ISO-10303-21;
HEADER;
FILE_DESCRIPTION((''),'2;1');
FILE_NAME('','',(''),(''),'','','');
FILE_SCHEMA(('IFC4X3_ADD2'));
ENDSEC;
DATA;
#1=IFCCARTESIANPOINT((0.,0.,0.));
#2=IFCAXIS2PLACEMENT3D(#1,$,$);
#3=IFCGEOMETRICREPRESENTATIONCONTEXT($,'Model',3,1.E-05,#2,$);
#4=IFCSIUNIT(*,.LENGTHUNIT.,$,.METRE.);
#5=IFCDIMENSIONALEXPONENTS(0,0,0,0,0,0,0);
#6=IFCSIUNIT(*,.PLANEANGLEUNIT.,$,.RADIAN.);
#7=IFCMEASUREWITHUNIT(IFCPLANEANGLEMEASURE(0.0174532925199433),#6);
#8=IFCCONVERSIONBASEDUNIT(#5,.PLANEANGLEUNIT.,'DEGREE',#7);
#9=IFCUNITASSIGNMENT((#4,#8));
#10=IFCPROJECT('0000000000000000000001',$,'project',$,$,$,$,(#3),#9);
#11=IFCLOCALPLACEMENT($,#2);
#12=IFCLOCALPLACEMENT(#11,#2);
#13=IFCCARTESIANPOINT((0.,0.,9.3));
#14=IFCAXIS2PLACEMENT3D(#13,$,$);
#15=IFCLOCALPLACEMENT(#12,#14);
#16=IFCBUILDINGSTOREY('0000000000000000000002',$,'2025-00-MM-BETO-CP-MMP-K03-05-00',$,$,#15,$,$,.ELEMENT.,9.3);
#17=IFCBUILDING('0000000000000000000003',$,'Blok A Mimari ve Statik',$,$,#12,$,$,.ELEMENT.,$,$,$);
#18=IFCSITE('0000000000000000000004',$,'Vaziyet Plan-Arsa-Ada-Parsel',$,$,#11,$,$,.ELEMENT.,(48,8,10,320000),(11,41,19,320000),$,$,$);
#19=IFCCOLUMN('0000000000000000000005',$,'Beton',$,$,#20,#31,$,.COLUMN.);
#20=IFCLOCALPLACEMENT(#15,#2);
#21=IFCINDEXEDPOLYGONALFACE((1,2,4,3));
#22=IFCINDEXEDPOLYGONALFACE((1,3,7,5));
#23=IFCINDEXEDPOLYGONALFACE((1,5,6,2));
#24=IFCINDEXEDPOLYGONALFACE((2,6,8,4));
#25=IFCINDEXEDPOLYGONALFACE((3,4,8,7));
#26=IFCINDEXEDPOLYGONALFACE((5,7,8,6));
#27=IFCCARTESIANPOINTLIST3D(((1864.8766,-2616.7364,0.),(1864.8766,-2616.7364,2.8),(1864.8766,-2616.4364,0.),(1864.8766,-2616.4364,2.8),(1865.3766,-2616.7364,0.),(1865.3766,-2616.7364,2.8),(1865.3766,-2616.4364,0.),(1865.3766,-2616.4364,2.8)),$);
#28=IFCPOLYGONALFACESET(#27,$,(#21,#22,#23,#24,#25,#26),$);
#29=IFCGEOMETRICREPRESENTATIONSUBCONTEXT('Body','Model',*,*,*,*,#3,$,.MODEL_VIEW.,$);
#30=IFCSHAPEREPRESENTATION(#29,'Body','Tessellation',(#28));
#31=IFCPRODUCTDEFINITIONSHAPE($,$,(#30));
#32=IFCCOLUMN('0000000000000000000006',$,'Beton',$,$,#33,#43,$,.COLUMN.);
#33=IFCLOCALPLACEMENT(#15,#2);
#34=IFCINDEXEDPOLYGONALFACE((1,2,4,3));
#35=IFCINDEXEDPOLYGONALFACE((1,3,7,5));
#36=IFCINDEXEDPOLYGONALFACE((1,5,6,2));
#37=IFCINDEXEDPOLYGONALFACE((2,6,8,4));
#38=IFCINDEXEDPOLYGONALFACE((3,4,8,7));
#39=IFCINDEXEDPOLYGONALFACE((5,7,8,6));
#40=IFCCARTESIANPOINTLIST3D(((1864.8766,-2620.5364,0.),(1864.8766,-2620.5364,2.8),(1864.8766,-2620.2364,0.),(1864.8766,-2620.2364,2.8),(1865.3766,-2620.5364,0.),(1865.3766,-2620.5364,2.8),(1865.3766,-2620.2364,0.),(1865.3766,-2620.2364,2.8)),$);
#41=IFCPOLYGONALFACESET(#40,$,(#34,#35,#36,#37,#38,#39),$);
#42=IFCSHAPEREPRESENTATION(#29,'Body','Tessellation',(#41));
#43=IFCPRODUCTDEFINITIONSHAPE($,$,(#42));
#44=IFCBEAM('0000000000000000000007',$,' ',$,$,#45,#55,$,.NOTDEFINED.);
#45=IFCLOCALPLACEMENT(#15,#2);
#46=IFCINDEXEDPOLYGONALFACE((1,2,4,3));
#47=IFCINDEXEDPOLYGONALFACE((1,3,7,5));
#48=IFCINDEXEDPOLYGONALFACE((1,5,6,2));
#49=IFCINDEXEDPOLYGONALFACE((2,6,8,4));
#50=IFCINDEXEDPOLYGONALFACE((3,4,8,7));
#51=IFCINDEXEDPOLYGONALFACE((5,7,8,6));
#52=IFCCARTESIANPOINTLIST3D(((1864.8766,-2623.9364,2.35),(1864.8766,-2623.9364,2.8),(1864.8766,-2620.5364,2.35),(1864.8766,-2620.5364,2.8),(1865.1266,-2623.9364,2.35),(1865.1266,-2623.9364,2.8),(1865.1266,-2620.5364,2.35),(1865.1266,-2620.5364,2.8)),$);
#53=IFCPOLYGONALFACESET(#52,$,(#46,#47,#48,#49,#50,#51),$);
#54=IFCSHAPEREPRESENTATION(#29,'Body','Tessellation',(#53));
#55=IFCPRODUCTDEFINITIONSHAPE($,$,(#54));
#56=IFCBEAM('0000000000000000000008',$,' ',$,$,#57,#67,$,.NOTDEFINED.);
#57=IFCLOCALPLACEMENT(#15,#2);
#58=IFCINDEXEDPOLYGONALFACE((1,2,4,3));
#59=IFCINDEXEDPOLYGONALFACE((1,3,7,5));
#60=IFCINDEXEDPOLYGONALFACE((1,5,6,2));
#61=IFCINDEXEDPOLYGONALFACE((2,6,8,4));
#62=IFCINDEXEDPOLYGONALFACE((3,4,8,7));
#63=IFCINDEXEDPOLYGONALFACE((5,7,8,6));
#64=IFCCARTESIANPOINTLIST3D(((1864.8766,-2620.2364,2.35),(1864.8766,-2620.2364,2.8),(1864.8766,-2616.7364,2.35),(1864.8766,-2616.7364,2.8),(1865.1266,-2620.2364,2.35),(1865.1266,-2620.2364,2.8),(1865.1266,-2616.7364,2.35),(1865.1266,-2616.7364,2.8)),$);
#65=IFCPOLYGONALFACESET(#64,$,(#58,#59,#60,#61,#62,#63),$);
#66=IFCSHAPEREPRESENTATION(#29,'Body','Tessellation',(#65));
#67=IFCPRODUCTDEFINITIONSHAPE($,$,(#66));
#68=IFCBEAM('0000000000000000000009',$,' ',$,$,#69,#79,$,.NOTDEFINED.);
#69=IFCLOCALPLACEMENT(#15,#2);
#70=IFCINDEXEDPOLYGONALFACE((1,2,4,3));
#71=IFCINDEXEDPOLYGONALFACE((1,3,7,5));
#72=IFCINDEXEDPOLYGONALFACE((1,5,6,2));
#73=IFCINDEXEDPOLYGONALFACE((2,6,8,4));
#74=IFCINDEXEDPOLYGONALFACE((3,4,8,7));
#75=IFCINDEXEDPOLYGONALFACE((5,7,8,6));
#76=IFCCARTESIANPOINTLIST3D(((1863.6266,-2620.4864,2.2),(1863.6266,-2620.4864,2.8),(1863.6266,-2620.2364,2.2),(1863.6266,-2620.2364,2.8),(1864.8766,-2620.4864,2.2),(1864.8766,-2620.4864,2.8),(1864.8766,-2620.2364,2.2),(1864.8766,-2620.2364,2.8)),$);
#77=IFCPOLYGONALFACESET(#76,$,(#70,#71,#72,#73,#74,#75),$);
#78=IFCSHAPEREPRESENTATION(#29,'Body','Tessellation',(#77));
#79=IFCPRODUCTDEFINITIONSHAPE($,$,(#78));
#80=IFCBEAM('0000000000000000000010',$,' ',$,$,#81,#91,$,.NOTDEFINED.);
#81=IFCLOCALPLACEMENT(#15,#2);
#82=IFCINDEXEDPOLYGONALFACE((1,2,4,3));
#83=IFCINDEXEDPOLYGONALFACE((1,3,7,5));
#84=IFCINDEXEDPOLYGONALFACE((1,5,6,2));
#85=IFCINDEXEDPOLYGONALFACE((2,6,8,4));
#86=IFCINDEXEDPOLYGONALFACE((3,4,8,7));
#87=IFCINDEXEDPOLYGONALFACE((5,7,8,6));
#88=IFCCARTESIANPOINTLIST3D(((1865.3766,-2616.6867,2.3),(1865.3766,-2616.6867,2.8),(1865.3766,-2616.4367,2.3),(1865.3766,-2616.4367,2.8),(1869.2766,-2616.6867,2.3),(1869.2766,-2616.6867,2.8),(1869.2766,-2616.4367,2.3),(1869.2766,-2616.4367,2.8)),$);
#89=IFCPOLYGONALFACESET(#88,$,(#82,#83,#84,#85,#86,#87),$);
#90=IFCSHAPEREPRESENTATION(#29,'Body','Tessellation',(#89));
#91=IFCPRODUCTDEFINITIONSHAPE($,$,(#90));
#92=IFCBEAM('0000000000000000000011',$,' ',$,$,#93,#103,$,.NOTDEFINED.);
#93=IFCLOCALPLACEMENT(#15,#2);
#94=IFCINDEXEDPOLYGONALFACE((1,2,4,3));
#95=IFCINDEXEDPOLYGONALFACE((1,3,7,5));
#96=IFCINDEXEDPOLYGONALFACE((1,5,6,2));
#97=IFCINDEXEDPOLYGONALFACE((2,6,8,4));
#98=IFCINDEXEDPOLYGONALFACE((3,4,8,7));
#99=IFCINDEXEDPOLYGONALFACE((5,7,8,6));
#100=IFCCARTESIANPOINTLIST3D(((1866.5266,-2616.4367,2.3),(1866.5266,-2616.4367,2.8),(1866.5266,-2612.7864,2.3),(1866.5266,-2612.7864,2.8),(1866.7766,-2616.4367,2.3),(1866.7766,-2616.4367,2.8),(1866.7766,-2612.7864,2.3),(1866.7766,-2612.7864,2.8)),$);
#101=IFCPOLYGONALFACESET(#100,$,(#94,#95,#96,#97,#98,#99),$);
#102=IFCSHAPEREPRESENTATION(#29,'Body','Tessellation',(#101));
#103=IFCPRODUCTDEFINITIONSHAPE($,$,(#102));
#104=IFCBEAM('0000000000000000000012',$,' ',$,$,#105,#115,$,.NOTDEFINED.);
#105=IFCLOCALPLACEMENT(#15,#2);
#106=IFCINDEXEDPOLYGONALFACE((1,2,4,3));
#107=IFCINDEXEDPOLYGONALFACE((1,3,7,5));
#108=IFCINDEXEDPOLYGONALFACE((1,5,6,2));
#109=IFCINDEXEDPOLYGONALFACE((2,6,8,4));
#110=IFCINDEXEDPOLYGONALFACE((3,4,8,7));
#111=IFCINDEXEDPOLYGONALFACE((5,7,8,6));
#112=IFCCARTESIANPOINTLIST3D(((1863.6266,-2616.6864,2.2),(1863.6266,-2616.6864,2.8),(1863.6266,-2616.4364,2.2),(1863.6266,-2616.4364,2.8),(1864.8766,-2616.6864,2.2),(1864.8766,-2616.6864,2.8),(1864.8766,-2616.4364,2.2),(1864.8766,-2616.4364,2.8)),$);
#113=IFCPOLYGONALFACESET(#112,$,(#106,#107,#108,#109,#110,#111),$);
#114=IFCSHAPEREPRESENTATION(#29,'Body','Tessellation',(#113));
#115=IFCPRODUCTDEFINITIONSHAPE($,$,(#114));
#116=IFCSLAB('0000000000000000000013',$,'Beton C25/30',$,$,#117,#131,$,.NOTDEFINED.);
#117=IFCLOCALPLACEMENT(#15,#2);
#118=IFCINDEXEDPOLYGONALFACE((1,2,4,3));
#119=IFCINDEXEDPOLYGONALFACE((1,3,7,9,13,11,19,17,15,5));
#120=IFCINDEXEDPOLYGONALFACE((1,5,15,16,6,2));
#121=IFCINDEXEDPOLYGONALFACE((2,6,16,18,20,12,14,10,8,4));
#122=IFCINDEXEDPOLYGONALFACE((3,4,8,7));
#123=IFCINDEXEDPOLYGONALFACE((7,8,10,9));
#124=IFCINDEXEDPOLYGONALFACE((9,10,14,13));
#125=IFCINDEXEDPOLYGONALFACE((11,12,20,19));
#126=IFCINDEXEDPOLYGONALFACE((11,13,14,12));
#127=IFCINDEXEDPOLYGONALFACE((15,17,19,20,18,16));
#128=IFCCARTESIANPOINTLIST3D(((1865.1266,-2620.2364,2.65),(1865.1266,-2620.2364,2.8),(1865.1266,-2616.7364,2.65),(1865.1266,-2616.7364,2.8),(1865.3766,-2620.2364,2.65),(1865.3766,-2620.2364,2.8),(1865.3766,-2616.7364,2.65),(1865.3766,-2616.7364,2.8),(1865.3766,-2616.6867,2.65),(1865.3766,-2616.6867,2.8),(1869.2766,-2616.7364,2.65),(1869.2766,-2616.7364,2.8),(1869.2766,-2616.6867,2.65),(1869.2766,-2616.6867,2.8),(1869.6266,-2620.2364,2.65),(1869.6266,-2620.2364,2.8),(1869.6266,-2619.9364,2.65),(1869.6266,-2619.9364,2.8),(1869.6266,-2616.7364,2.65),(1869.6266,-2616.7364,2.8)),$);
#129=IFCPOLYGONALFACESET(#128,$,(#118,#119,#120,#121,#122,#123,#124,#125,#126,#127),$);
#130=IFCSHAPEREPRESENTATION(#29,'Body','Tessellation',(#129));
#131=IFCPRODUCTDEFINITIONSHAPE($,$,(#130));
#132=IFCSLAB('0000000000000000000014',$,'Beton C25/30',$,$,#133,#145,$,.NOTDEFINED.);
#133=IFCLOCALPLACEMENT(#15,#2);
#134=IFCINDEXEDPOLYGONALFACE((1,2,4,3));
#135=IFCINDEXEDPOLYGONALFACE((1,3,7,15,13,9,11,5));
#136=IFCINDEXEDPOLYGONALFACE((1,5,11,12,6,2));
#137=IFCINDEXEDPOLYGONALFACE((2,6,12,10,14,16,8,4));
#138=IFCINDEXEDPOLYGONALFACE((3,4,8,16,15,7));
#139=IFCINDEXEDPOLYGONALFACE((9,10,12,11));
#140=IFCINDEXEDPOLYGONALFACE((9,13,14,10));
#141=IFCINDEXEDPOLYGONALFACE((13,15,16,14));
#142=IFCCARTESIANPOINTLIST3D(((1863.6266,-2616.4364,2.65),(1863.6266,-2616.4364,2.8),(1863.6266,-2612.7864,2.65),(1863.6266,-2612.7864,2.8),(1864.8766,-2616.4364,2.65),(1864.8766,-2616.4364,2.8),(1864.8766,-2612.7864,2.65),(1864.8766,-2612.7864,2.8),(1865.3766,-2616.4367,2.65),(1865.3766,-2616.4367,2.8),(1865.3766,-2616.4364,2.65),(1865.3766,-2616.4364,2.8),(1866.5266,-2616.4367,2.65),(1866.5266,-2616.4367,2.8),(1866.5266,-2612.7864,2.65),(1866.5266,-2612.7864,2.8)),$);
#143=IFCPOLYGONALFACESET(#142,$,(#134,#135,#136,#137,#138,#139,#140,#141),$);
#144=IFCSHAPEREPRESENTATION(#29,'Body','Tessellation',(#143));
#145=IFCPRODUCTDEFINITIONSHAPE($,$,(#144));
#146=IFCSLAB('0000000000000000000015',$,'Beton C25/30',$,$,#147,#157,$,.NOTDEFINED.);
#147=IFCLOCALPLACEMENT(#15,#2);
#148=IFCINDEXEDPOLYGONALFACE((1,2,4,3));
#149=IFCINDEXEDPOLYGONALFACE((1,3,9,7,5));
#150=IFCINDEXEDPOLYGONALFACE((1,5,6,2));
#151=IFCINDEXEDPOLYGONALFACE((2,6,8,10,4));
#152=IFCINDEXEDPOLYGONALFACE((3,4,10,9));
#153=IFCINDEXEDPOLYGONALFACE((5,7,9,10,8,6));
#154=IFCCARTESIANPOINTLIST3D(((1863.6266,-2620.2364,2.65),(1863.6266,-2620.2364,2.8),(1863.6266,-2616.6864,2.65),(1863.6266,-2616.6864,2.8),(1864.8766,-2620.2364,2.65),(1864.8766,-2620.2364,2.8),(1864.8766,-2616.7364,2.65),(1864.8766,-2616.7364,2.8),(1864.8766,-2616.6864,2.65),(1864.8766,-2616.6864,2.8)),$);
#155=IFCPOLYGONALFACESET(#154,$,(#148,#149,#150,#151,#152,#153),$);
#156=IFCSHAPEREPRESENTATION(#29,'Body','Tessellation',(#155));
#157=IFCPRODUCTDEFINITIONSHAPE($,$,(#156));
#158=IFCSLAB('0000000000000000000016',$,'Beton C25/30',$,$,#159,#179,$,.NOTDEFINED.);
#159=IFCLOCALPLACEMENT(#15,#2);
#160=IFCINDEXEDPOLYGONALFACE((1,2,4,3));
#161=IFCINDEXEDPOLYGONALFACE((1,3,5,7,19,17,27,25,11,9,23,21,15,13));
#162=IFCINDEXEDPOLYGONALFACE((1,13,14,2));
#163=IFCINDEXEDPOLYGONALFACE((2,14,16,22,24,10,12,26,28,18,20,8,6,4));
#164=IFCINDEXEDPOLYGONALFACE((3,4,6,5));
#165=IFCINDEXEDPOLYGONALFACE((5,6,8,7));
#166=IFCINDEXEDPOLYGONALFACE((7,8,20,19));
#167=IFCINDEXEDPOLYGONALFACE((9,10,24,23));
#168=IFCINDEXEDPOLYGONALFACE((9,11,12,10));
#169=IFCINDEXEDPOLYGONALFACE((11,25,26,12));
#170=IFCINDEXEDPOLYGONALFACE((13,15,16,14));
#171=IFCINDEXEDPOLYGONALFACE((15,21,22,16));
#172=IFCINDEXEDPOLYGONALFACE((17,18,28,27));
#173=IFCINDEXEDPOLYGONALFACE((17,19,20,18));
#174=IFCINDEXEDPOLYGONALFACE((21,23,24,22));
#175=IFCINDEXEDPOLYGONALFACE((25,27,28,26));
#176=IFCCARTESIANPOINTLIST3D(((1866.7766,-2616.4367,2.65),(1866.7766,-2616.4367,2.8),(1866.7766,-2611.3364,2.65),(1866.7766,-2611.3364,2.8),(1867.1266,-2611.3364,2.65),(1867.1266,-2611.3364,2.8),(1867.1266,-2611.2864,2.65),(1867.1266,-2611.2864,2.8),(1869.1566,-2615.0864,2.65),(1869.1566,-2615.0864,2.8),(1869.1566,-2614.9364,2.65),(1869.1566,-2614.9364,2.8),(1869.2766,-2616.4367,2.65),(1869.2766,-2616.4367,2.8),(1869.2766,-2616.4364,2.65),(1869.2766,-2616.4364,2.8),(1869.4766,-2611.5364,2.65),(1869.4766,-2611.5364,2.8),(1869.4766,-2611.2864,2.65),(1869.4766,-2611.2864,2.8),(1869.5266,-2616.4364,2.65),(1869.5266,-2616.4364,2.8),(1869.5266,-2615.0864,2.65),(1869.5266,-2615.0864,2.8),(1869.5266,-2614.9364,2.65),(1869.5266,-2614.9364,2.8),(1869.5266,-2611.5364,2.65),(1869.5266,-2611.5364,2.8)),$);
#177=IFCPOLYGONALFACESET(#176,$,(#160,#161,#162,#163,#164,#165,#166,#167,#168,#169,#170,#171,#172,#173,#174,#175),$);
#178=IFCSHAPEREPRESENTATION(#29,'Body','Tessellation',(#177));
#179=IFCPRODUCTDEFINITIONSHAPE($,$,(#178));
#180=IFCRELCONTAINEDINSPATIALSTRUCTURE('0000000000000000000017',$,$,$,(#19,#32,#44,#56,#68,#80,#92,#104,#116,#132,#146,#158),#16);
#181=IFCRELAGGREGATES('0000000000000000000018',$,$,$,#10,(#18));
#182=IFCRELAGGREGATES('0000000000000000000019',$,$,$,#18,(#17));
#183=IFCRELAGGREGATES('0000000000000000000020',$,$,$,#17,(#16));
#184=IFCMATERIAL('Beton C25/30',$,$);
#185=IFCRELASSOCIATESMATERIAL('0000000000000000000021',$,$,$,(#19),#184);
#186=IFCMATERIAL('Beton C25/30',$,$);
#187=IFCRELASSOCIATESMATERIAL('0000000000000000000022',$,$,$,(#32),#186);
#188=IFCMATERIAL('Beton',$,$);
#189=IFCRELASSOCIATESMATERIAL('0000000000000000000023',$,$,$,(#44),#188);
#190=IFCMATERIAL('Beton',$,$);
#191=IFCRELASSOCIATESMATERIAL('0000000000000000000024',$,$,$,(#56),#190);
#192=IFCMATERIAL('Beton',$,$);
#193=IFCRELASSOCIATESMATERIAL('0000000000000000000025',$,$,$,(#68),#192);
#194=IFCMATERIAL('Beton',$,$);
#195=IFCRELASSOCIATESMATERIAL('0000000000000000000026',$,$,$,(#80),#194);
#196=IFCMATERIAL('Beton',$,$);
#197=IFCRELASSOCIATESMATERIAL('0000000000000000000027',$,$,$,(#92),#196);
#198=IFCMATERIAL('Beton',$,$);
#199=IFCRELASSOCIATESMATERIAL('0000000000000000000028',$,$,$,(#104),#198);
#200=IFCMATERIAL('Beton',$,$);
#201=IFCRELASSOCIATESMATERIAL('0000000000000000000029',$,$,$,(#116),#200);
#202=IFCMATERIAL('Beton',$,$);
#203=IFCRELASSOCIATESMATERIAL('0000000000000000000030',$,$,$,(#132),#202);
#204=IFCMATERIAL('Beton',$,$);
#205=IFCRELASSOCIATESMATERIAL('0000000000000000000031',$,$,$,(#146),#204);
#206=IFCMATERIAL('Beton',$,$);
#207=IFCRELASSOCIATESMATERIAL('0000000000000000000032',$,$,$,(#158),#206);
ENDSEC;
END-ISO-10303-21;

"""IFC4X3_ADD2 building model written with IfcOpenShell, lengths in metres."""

from ifc_helpers import new_model, entity, si_unit, converted_unit, frame, frame_2d, origin, origin_with_axes, place, context, subcontext, project, spatial, polyline, rectangle, outline, extrude, material, element, save


model = new_model("IFC4X3_ADD2")

# Units and contexts
model_context = context("Model", 3, precision=1e-05, world=origin())
body_context = subcontext(model_context, "Body", "Model", "MODEL_VIEW")
ifc_project = project(units=[si_unit("LENGTHUNIT", "METRE"), converted_unit("PLANEANGLEUNIT", "DEGREE", entity("IfcPlaneAngleMeasure", 0.0174532925199433), si_unit("PLANEANGLEUNIT", "RADIAN"), dimensions=[0, 0, 0, 0, 0, 0, 0])], contexts=[model_context])

# Site, building, storey
site_placement = place(None, origin())
site = spatial("IfcSite", under=ifc_project, at=site_placement, Name="Vaziyet Plan-Arsa-Ada-Parsel", CompositionType="ELEMENT", RefLatitude=(48, 8, 10, 320000), RefLongitude=(11, 41, 19, 320000))
building_placement = place(site_placement, origin())
building = spatial("IfcBuilding", under=site, at=building_placement, Name="Blok A Mimari ve Statik", CompositionType="ELEMENT")
storey_placement = place(building_placement, frame((0.0, 0.0, 9.3)))
storey = spatial("IfcBuildingStorey", under=building, at=storey_placement, Name="2025-00-MM-BETO-CP-MMP-K03-05-00", CompositionType="ELEMENT", Elevation=9.3)

# Columns
ifc_material_1 = material(Name="Beton C25/30")
column_1_placement = place(storey_placement, frame((1864.8766, -2616.7364, 0.0)))
element("IfcColumn", 1, at=column_1_placement, inside=storey, material=ifc_material_1, Name="Beton", PredefinedType="COLUMN", context=body_context, shape_type="SweptSolid", body=[
    extrude(outline(polyline([(0.0, 0.0), (0.5, 0.0), (0.5, 0.3), (0.0, 0.3), (0.0, 0.0)])), origin_with_axes(), (0.0, 0.0, 1.0), 2.8),
])
ifc_material_2 = material(Name="Beton C25/30")
column_2_placement = place(storey_placement, frame((1864.8766, -2620.5364, 0.0)))
element("IfcColumn", 2, at=column_2_placement, inside=storey, material=ifc_material_2, Name="Beton", PredefinedType="COLUMN", context=body_context, shape_type="SweptSolid", body=[
    extrude(outline(polyline([(0.0, 0.0), (0.5, 0.0), (0.5, 0.3), (0.0, 0.3), (0.0, 0.0)])), origin_with_axes(), (0.0, 0.0, 1.0), 2.8),
])

# Beams
ifc_material_3 = material(Name="Beton")
beam_1_placement = place(storey_placement, frame((1864.8766, -2620.5364, 2.35), z_axis=(0.0, 0.0, 1.0), x_axis=(0.0, -1.0, 0.0)))
element("IfcBeam", 3, at=beam_1_placement, inside=storey, material=ifc_material_3, Name=" ", PredefinedType="NOTDEFINED", context=body_context, shape_type="SweptSolid", body=[
    extrude(rectangle(XDim=0.25, YDim=0.45, at=frame_2d((0.125, 0.225), x_axis=(1.0, 0.0))), frame((0.0, 0.0, 0.0), z_axis=(1.0, 0.0, 0.0), x_axis=(0.0, 1.0, 0.0)), (0.0, 0.0, 1.0), 3.4),
])
ifc_material_4 = material(Name="Beton")
beam_2_placement = place(storey_placement, frame((1864.8766, -2616.7364, 2.35), z_axis=(0.0, 0.0, 1.0), x_axis=(0.0, -1.0, 0.0)))
element("IfcBeam", 4, at=beam_2_placement, inside=storey, material=ifc_material_4, Name=" ", PredefinedType="NOTDEFINED", context=body_context, shape_type="SweptSolid", body=[
    extrude(rectangle(XDim=0.25, YDim=0.45, at=frame_2d((0.125, 0.225), x_axis=(1.0, 0.0))), frame((0.0, 0.0, 0.0), z_axis=(1.0, 0.0, 0.0), x_axis=(0.0, 1.0, 0.0)), (0.0, 0.0, 1.0), 3.5),
])
ifc_material_5 = material(Name="Beton")
beam_3_placement = place(storey_placement, frame((1863.6266, -2620.4864, 2.2)))
element("IfcBeam", 5, at=beam_3_placement, inside=storey, material=ifc_material_5, Name=" ", PredefinedType="NOTDEFINED", context=body_context, shape_type="SweptSolid", body=[
    extrude(rectangle(XDim=0.25, YDim=0.6, at=frame_2d((0.125, 0.3), x_axis=(1.0, 0.0))), frame((0.0, 0.0, 0.0), z_axis=(1.0, 0.0, 0.0), x_axis=(0.0, 1.0, 0.0)), (0.0, 0.0, 1.0), 1.25),
])
ifc_material_6 = material(Name="Beton")
beam_4_placement = place(storey_placement, frame((1865.3766, -2616.6867, 2.3)))
element("IfcBeam", 6, at=beam_4_placement, inside=storey, material=ifc_material_6, Name=" ", PredefinedType="NOTDEFINED", context=body_context, shape_type="SweptSolid", body=[
    extrude(rectangle(XDim=0.25, YDim=0.5, at=frame_2d((0.125, 0.25), x_axis=(1.0, 0.0))), frame((0.0, 0.0, 0.0), z_axis=(1.0, 0.0, 0.0), x_axis=(0.0, 1.0, 0.0)), (0.0, 0.0, 1.0), 3.9),
])
ifc_material_7 = material(Name="Beton")
beam_5_placement = place(storey_placement, frame((1866.7766, -2616.4367, 2.3), z_axis=(0.0, 0.0, 1.0), x_axis=(0.0, 1.0, 0.0)))
element("IfcBeam", 7, at=beam_5_placement, inside=storey, material=ifc_material_7, Name=" ", PredefinedType="NOTDEFINED", context=body_context, shape_type="SweptSolid", body=[
    extrude(rectangle(XDim=0.25, YDim=0.5, at=frame_2d((0.125, 0.25), x_axis=(1.0, 0.0))), frame((0.0, 0.0, 0.0), z_axis=(1.0, 0.0, 0.0), x_axis=(0.0, 1.0, 0.0)), (0.0, 0.0, 1.0), 3.6503),
])
ifc_material_8 = material(Name="Beton")
beam_6_placement = place(storey_placement, frame((1863.6266, -2616.6864, 2.2)))
element("IfcBeam", 8, at=beam_6_placement, inside=storey, material=ifc_material_8, Name=" ", PredefinedType="NOTDEFINED", context=body_context, shape_type="SweptSolid", body=[
    extrude(rectangle(XDim=0.25, YDim=0.6, at=frame_2d((0.125, 0.3), x_axis=(1.0, 0.0))), frame((0.0, 0.0, 0.0), z_axis=(1.0, 0.0, 0.0), x_axis=(0.0, 1.0, 0.0)), (0.0, 0.0, 1.0), 1.25),
])

# Slabs
ifc_material_9 = material(Name="Beton")
slab_1_placement = place(storey_placement, frame((1865.1266, -2620.2364, 2.65)))
element("IfcSlab", 9, at=slab_1_placement, inside=storey, material=ifc_material_9, Name="Beton C25/30", PredefinedType="NOTDEFINED", context=body_context, shape_type="SweptSolid", body=[
    extrude(outline(polyline([(4.15, 3.5497), (0.25, 3.5497), (0.25, 3.5), (0.0, 3.5), (0.0, 0.0), (0.25, 0.0), (4.5, 0.0), (4.5, 0.3), (4.5, 3.5), (4.15, 3.5), (4.15, 3.5497)])), origin_with_axes(), (0.0, 0.0, 1.0), 0.15),
])
ifc_material_10 = material(Name="Beton")
slab_2_placement = place(storey_placement, frame((1863.6266, -2616.4367, 2.65)))
element("IfcSlab", 10, at=slab_2_placement, inside=storey, material=ifc_material_10, Name="Beton C25/30", PredefinedType="NOTDEFINED", context=body_context, shape_type="SweptSolid", body=[
    extrude(outline(polyline([(0.0, 3.6503), (0.0, 0.0003), (1.25, 0.0003), (1.75, 0.0003), (1.75, 0.0), (2.9, 0.0), (2.9, 3.6503), (1.25, 3.6503), (0.0, 3.6503)])), origin_with_axes(), (0.0, 0.0, 1.0), 0.15),
])
ifc_material_11 = material(Name="Beton")
slab_3_placement = place(storey_placement, frame((1863.6266, -2620.2364, 2.65)))
element("IfcSlab", 11, at=slab_3_placement, inside=storey, material=ifc_material_11, Name="Beton C25/30", PredefinedType="NOTDEFINED", context=body_context, shape_type="SweptSolid", body=[
    extrude(outline(polyline([(0.0, 3.55), (0.0, 0.0), (1.25, 0.0), (1.25, 3.5), (1.25, 3.55), (0.0, 3.55)])), origin_with_axes(), (0.0, 0.0, 1.0), 0.15),
])

# Slab, opening
ifc_material_12 = material(Name="Beton")
slab_4_placement = place(storey_placement, frame((1866.7766, -2616.4367, 2.65)))
slab_4 = element("IfcSlab", 12, at=slab_4_placement, inside=storey, material=ifc_material_12, Name="Beton C25/30", PredefinedType="NOTDEFINED", context=body_context, shape_type="SweptSolid", body=[
    extrude(outline(polyline([(2.75, 1.3503), (2.38, 1.3503), (2.38, 1.5003), (2.75, 1.5003), (2.75, 4.9003), (2.7, 4.9003), (2.7, 5.1503), (0.35, 5.1503), (0.35, 5.1003), (0.0, 5.1003), (0.0, 3.9003), (0.0, 3.6503), (0.0, 0.0), (2.5, 0.0), (2.5, 0.0003), (2.75, 0.0003), (2.75, 1.3503)])), origin_with_axes(), (0.0, 0.0, 1.0), 0.15),
])
opening_placement = place(slab_4_placement, frame((2.38, 1.3503, 0.0)))
element("IfcOpeningElement", 13, at=opening_placement, cuts=slab_4, PredefinedType="OPENING", context=body_context, shape_type="SweptSolid", body=[
    extrude(rectangle(XDim=0.37, YDim=0.15, at=frame_2d((0.0, 0.0), x_axis=(-1.0, 0.0))), frame((0.185, 0.075, 0.0), z_axis=(0.0, 0.0, 1.0), x_axis=(1.0, 0.0, 0.0)), (0.0, 0.0, 1.0), 0.15),
])

save(model, "model.ifc")
